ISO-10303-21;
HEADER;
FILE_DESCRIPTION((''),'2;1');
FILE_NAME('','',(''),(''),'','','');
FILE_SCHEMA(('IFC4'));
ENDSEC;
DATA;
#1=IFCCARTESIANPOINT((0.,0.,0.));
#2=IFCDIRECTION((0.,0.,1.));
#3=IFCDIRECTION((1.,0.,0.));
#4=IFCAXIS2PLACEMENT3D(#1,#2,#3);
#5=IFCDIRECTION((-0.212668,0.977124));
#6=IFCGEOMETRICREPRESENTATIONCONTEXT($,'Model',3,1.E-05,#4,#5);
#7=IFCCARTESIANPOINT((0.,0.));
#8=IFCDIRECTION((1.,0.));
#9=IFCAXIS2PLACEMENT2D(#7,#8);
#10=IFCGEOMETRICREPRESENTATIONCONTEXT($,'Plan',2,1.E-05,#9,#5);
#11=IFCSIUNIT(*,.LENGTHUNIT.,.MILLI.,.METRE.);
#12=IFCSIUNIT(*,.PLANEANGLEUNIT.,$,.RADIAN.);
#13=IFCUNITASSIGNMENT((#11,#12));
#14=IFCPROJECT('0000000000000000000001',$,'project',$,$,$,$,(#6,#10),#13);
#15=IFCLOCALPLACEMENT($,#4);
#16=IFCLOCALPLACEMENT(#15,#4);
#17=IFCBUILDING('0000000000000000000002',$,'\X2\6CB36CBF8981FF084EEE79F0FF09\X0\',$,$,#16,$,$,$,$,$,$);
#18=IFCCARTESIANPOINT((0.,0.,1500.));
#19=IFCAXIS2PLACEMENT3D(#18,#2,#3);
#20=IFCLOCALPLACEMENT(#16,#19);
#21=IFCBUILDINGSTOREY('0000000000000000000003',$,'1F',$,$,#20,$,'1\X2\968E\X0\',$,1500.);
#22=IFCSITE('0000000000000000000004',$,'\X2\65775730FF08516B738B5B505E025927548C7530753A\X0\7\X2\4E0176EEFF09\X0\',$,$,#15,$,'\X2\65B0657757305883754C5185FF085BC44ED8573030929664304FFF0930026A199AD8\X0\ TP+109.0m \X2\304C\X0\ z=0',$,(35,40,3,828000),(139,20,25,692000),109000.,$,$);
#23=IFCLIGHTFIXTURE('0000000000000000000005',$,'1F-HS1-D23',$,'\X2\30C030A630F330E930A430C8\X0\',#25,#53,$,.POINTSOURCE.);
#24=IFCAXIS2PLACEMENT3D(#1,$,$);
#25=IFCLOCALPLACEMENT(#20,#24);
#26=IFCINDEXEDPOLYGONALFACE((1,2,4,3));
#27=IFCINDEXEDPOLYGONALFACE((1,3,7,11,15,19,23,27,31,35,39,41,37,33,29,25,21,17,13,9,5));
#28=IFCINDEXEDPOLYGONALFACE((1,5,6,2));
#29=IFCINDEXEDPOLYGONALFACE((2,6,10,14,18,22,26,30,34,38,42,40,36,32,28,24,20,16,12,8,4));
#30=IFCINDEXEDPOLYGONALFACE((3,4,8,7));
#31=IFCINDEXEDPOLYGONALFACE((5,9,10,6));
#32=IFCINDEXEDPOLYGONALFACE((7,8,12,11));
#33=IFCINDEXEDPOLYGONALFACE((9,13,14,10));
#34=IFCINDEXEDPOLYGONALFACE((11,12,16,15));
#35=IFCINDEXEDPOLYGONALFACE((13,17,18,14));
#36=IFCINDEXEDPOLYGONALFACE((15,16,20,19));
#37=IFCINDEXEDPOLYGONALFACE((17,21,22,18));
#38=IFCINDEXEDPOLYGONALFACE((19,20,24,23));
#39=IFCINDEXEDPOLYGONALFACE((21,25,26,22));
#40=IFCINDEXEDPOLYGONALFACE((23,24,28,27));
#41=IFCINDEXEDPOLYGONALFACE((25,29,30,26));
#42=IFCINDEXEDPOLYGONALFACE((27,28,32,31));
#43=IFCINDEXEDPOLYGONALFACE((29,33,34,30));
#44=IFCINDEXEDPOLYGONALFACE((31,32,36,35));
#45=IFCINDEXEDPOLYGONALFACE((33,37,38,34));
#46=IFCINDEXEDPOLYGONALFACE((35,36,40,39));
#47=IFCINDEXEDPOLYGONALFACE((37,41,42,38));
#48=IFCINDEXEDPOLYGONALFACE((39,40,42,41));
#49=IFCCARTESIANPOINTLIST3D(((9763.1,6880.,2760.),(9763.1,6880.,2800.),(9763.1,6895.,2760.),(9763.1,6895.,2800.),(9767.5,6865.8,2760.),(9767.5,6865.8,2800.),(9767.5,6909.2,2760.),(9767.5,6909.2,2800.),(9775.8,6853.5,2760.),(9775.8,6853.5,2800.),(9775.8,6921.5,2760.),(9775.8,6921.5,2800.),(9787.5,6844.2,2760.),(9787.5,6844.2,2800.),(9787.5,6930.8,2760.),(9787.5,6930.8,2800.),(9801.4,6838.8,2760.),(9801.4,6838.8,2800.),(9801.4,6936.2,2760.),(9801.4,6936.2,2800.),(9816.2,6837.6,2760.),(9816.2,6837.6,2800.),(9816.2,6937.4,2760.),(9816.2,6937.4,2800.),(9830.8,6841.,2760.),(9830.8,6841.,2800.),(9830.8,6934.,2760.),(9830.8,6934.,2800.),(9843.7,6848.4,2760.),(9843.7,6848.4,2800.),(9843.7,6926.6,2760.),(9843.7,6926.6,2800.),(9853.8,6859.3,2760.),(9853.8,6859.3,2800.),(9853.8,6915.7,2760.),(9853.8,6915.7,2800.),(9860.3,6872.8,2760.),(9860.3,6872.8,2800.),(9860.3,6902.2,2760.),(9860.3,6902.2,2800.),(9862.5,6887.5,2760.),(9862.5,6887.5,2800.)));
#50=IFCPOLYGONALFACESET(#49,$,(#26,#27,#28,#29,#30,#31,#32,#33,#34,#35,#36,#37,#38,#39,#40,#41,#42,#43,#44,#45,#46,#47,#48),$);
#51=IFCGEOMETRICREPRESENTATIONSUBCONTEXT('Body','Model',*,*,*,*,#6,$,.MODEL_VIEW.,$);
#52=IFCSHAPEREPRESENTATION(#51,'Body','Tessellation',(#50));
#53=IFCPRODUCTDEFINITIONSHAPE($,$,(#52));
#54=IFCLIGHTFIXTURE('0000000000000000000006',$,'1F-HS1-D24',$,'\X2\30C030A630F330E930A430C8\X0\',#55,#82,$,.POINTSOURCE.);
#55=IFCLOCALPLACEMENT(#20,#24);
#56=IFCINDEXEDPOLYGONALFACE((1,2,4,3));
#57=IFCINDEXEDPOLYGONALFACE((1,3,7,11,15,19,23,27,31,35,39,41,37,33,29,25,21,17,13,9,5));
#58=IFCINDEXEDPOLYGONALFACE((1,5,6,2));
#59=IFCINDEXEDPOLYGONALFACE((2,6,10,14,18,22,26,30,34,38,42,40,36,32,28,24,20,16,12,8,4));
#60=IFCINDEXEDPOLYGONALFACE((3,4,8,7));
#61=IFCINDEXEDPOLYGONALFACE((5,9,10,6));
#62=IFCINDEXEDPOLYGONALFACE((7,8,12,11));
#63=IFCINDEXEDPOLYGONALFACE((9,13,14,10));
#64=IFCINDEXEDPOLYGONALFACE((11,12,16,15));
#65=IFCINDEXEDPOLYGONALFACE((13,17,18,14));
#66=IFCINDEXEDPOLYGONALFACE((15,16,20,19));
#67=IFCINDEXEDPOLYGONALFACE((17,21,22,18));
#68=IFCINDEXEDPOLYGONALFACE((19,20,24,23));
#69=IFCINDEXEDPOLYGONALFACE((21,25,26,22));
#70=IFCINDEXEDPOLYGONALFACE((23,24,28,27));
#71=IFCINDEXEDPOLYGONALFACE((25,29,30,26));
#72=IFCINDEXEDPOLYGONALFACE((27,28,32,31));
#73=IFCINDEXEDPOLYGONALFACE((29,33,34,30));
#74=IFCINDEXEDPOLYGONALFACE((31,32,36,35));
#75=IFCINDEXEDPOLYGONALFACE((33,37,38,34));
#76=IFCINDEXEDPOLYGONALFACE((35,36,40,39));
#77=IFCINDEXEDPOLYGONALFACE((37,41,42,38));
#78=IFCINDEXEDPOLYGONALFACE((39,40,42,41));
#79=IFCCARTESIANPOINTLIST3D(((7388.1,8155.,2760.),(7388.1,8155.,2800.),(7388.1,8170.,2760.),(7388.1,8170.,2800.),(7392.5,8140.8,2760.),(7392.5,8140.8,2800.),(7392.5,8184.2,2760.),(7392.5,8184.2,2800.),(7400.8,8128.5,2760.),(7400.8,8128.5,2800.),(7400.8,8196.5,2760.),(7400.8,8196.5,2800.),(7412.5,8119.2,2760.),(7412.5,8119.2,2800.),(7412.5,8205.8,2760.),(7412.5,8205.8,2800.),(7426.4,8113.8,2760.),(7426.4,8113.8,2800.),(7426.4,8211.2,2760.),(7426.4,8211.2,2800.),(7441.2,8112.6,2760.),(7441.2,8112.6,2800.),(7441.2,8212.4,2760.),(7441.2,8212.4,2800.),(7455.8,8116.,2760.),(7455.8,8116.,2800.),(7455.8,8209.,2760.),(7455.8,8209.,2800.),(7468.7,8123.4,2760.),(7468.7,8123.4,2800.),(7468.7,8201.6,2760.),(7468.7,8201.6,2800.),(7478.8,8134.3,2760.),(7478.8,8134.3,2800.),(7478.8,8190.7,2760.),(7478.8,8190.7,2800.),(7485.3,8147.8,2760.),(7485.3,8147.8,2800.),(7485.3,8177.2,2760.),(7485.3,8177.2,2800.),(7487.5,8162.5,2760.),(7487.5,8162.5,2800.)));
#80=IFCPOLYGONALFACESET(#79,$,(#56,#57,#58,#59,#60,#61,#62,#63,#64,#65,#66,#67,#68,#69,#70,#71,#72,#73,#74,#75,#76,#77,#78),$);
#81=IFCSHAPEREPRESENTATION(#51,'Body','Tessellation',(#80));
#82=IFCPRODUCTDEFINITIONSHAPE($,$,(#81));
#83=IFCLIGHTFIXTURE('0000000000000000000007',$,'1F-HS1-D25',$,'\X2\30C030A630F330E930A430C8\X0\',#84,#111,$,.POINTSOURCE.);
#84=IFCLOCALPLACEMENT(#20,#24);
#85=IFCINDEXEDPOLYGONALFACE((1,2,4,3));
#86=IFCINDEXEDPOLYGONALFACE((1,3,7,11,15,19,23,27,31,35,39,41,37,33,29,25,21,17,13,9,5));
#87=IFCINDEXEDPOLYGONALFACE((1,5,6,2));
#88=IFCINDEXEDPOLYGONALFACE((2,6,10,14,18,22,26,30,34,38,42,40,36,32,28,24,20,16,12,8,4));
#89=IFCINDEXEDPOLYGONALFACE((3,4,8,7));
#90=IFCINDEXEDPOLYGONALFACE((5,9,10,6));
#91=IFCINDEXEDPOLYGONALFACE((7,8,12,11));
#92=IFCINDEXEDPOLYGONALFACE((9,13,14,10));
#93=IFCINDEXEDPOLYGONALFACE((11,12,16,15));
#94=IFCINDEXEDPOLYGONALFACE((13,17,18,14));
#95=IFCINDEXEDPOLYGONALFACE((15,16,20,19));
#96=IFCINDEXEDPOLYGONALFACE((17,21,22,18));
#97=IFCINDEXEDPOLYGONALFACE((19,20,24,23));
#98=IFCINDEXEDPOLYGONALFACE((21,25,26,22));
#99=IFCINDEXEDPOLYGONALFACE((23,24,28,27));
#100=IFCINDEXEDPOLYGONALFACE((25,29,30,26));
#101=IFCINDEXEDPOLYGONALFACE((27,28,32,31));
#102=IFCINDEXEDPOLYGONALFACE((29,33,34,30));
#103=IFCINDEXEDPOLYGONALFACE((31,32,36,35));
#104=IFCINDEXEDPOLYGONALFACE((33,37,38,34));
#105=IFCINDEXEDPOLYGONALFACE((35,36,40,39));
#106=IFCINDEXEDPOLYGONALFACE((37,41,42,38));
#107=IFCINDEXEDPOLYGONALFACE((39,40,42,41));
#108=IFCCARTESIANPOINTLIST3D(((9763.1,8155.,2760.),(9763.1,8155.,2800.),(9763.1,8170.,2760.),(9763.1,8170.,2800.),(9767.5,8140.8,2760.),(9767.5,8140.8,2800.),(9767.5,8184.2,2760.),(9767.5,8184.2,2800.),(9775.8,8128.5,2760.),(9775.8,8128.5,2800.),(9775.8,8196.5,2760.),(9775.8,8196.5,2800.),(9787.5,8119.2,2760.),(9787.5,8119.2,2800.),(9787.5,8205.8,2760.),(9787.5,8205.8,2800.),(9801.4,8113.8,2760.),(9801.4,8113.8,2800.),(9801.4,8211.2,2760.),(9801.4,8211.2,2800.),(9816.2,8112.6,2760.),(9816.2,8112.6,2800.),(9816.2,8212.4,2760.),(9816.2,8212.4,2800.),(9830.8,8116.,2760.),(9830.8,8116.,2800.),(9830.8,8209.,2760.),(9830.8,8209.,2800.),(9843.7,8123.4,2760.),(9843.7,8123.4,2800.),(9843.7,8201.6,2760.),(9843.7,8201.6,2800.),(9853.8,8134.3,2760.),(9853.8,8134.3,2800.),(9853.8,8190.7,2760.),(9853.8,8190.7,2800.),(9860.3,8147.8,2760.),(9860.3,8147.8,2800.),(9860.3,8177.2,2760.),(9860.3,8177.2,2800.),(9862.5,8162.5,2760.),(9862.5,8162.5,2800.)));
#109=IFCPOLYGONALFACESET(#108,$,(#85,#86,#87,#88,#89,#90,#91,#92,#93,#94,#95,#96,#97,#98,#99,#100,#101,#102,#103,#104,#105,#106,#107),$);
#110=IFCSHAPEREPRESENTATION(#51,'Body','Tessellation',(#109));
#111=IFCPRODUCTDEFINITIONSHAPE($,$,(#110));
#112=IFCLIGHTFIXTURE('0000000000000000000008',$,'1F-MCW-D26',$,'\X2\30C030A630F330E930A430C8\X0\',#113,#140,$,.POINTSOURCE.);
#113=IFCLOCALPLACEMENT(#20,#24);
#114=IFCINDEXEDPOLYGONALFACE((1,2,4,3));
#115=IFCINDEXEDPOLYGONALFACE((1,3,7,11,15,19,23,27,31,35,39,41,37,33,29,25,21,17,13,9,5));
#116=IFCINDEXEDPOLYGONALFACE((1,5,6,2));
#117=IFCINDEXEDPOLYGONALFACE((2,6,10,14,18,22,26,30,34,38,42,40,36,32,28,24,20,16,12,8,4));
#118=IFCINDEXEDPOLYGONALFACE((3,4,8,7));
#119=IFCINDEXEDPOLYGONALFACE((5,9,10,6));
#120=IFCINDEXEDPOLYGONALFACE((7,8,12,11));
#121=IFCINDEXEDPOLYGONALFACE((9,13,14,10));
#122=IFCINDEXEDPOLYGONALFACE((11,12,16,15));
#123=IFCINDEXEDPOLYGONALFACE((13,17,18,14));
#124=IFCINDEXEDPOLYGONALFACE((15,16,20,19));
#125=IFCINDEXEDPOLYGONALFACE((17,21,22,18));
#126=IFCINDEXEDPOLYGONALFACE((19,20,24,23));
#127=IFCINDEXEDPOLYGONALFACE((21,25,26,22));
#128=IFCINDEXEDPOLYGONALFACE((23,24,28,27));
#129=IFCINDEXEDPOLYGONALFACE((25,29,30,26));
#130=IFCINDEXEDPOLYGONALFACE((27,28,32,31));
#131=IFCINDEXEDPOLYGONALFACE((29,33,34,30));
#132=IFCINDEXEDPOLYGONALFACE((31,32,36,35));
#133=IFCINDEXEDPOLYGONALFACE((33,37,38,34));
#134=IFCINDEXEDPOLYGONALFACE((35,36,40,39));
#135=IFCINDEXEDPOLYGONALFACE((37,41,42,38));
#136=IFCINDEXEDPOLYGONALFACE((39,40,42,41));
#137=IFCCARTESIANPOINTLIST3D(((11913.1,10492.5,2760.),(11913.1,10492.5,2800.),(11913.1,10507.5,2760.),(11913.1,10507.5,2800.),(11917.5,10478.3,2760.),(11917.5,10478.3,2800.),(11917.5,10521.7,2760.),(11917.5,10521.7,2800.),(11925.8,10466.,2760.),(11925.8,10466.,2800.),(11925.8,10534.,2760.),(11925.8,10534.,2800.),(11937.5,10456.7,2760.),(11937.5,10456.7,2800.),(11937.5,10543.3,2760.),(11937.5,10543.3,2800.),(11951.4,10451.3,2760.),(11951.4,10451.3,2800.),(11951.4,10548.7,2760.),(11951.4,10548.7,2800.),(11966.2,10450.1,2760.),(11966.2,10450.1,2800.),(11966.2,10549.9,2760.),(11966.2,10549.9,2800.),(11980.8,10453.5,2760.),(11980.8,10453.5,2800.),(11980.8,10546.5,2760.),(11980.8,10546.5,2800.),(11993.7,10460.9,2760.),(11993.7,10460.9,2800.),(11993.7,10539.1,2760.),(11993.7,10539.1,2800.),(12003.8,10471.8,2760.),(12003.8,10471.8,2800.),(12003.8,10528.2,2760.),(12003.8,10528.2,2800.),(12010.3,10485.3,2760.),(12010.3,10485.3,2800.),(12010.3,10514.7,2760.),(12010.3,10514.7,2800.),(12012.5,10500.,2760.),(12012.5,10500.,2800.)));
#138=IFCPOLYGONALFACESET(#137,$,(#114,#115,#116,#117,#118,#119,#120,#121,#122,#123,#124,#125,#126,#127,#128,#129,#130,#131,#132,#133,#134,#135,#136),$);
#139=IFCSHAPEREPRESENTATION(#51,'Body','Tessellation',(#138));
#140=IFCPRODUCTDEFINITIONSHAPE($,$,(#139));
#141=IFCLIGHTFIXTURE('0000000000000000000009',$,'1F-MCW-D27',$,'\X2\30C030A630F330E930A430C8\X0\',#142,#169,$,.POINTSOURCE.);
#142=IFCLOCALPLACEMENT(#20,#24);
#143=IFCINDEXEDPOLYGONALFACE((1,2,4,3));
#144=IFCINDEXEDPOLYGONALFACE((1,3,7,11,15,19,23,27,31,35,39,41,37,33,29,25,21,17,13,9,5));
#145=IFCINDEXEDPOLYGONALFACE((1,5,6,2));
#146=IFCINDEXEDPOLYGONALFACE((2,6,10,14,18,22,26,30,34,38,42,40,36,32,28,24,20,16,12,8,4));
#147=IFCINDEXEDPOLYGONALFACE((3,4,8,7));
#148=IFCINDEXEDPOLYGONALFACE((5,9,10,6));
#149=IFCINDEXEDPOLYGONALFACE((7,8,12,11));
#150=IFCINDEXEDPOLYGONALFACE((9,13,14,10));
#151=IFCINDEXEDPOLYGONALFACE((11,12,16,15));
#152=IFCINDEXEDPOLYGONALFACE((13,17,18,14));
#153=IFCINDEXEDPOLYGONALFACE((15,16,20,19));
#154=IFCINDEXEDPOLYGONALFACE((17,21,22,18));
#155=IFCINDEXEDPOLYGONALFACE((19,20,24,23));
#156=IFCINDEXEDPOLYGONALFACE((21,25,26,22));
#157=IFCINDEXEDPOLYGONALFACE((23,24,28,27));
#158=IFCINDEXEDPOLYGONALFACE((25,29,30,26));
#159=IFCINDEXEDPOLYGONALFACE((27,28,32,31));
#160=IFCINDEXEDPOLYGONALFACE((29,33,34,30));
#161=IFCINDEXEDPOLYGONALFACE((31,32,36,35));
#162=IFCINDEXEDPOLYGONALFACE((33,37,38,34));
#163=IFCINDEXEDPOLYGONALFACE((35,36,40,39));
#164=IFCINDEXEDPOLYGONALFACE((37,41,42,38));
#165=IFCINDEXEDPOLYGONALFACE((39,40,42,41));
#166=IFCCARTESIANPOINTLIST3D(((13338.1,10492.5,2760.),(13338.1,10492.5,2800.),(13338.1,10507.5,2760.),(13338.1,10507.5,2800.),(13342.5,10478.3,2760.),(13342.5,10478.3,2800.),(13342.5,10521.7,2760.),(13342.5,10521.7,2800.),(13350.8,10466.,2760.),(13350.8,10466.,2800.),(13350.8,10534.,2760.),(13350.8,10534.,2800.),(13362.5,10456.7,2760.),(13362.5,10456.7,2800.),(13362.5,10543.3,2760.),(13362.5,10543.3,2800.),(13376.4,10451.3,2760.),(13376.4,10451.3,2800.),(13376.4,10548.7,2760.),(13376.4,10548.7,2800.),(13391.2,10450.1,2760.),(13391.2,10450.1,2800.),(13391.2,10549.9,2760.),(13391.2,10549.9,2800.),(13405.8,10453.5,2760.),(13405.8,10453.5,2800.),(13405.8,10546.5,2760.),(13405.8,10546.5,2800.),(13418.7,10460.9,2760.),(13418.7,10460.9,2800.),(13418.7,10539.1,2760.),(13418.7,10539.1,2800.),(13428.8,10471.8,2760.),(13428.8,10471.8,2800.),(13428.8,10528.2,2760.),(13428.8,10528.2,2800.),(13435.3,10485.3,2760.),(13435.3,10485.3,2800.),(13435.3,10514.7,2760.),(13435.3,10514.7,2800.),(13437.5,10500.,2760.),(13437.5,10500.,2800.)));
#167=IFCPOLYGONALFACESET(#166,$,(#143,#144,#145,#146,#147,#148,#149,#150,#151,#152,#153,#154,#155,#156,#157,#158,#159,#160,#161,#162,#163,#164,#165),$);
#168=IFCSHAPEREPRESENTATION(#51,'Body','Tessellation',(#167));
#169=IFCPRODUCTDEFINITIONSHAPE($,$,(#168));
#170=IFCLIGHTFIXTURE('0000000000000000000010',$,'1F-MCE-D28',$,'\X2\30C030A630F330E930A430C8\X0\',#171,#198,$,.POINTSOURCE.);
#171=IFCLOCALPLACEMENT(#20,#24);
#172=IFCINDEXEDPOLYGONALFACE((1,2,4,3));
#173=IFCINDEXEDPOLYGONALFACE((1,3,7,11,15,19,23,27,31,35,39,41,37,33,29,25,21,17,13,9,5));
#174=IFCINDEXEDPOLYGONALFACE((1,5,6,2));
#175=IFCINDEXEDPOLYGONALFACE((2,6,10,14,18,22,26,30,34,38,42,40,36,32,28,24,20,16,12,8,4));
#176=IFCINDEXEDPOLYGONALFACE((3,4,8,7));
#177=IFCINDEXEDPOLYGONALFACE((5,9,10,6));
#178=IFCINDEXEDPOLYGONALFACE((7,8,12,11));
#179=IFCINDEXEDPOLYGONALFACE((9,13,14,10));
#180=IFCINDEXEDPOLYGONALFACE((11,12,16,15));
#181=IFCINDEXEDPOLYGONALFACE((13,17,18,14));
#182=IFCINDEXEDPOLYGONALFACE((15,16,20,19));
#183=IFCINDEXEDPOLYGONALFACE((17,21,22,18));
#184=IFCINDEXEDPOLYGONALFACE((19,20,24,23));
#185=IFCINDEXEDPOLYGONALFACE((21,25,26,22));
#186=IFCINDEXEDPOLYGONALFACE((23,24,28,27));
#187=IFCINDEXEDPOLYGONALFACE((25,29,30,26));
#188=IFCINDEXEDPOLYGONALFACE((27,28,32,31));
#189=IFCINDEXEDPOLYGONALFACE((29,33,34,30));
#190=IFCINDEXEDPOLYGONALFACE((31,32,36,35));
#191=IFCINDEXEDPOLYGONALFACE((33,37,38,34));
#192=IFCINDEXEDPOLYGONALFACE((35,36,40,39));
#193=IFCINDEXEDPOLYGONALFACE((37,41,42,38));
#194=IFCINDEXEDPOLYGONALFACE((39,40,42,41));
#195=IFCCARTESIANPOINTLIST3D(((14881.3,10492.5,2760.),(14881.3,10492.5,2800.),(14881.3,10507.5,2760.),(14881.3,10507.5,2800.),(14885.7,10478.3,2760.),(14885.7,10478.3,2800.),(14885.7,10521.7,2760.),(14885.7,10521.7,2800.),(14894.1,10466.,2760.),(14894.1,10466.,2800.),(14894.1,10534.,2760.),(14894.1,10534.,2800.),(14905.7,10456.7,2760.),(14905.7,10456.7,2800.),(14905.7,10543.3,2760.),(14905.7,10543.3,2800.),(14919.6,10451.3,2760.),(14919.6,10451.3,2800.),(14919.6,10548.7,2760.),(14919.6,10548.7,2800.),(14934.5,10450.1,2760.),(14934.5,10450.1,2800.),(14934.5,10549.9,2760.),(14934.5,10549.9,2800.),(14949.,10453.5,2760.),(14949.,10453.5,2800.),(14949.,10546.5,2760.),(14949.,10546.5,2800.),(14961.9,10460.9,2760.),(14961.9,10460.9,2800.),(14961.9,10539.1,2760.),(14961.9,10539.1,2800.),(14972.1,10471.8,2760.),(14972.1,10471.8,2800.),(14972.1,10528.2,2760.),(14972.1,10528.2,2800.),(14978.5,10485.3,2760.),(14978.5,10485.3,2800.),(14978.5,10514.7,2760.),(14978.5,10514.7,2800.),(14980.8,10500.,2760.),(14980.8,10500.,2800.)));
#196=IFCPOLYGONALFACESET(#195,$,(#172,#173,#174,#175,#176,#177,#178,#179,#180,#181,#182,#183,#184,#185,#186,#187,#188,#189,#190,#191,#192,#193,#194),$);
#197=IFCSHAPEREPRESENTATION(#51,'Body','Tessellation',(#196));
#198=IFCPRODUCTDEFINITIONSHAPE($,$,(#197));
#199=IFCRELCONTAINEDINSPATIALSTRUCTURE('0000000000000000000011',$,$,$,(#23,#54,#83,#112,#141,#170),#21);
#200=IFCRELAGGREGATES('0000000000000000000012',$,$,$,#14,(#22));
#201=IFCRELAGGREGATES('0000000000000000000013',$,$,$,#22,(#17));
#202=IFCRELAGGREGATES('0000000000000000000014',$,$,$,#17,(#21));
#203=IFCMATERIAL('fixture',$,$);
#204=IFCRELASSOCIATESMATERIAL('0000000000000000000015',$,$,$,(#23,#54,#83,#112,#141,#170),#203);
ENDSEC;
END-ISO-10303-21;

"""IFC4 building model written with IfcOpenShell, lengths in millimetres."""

from ifc_helpers import new_model, si_unit, direction, frame, frame_2d, origin_with_axes, origin_2d_with_axis, place, context, subcontext, project, spatial, circle, extrude, material, element, save


model = new_model("IFC4")

# Units and contexts
model_context = context("Model", 3, precision=1e-05, world=origin_with_axes(), true_north=direction((-0.212668, 0.977124)))
plan_context = context("Plan", 2, precision=1e-05, world=origin_2d_with_axis(), true_north=direction((-0.212668, 0.977124)))
body_context = subcontext(model_context, "Body", "Model", "MODEL_VIEW")
ifc_project = project(units=[si_unit("LENGTHUNIT", "METRE", prefix="MILLI"), si_unit("PLANEANGLEUNIT", "RADIAN")], contexts=[model_context, plan_context])

# Site, building, storey
site_placement = place(None, origin_with_axes())
site = spatial("IfcSite", under=ifc_project, at=site_placement, Name="敷地（八王子市大和田町7丁目）", LongName="新敷地境界内（寄付地を除く）。標高 TP+109.0m が z=0", RefLatitude=(35, 40, 3, 828000), RefLongitude=(139, 20, 25, 692000), RefElevation=109000.0)
building_placement = place(site_placement, origin_with_axes())
building = spatial("IfcBuilding", under=site, at=building_placement, Name="河沿要（仮称）")
storey_placement = place(building_placement, frame((0.0, 0.0, 1500.0), z_axis=(0.0, 0.0, 1.0), x_axis=(1.0, 0.0, 0.0)))
storey = spatial("IfcBuildingStorey", under=building, at=storey_placement, Name="1F", LongName="1階", Elevation=1500.0)

# Light fixtures
ifc_material = material(Name="fixture")
light_fixture_1_placement = place(storey_placement, origin_with_axes())
element("IfcLightFixture", 1, at=light_fixture_1_placement, inside=storey, material=ifc_material, Name="1F-HS1-D23", ObjectType="ダウンライト", PredefinedType="POINTSOURCE", context=body_context, shape_type="SweptSolid", body=[
    extrude(circle(Radius=50.0, at=frame_2d((9812.5, 6887.5))), frame((0.0, 0.0, 2760.0)), (0.0, 0.0, 1.0), 40.0),
])
light_fixture_2_placement = place(storey_placement, origin_with_axes())
element("IfcLightFixture", 2, at=light_fixture_2_placement, inside=storey, material=ifc_material, Name="1F-HS1-D24", ObjectType="ダウンライト", PredefinedType="POINTSOURCE", context=body_context, shape_type="SweptSolid", body=[
    extrude(circle(Radius=50.0, at=frame_2d((7437.5, 8162.5))), frame((0.0, 0.0, 2760.0)), (0.0, 0.0, 1.0), 40.0),
])
light_fixture_3_placement = place(storey_placement, origin_with_axes())
element("IfcLightFixture", 3, at=light_fixture_3_placement, inside=storey, material=ifc_material, Name="1F-HS1-D25", ObjectType="ダウンライト", PredefinedType="POINTSOURCE", context=body_context, shape_type="SweptSolid", body=[
    extrude(circle(Radius=50.0, at=frame_2d((9812.5, 8162.5))), frame((0.0, 0.0, 2760.0)), (0.0, 0.0, 1.0), 40.0),
])
light_fixture_4_placement = place(storey_placement, origin_with_axes())
element("IfcLightFixture", 4, at=light_fixture_4_placement, inside=storey, material=ifc_material, Name="1F-MCW-D26", ObjectType="ダウンライト", PredefinedType="POINTSOURCE", context=body_context, shape_type="SweptSolid", body=[
    extrude(circle(Radius=50.0, at=frame_2d((11962.5, 10500.0))), frame((0.0, 0.0, 2760.0)), (0.0, 0.0, 1.0), 40.0),
])
light_fixture_5_placement = place(storey_placement, origin_with_axes())
element("IfcLightFixture", 5, at=light_fixture_5_placement, inside=storey, material=ifc_material, Name="1F-MCW-D27", ObjectType="ダウンライト", PredefinedType="POINTSOURCE", context=body_context, shape_type="SweptSolid", body=[
    extrude(circle(Radius=50.0, at=frame_2d((13387.5, 10500.0))), frame((0.0, 0.0, 2760.0)), (0.0, 0.0, 1.0), 40.0),
])
light_fixture_6_placement = place(storey_placement, origin_with_axes())
element("IfcLightFixture", 6, at=light_fixture_6_placement, inside=storey, material=ifc_material, Name="1F-MCE-D28", ObjectType="ダウンライト", PredefinedType="POINTSOURCE", context=body_context, shape_type="SweptSolid", body=[
    extrude(circle(Radius=50.0, at=frame_2d((14930.8, 10500.0))), frame((0.0, 0.0, 2760.0)), (0.0, 0.0, 1.0), 40.0),
])

save(model, "model.ifc")
